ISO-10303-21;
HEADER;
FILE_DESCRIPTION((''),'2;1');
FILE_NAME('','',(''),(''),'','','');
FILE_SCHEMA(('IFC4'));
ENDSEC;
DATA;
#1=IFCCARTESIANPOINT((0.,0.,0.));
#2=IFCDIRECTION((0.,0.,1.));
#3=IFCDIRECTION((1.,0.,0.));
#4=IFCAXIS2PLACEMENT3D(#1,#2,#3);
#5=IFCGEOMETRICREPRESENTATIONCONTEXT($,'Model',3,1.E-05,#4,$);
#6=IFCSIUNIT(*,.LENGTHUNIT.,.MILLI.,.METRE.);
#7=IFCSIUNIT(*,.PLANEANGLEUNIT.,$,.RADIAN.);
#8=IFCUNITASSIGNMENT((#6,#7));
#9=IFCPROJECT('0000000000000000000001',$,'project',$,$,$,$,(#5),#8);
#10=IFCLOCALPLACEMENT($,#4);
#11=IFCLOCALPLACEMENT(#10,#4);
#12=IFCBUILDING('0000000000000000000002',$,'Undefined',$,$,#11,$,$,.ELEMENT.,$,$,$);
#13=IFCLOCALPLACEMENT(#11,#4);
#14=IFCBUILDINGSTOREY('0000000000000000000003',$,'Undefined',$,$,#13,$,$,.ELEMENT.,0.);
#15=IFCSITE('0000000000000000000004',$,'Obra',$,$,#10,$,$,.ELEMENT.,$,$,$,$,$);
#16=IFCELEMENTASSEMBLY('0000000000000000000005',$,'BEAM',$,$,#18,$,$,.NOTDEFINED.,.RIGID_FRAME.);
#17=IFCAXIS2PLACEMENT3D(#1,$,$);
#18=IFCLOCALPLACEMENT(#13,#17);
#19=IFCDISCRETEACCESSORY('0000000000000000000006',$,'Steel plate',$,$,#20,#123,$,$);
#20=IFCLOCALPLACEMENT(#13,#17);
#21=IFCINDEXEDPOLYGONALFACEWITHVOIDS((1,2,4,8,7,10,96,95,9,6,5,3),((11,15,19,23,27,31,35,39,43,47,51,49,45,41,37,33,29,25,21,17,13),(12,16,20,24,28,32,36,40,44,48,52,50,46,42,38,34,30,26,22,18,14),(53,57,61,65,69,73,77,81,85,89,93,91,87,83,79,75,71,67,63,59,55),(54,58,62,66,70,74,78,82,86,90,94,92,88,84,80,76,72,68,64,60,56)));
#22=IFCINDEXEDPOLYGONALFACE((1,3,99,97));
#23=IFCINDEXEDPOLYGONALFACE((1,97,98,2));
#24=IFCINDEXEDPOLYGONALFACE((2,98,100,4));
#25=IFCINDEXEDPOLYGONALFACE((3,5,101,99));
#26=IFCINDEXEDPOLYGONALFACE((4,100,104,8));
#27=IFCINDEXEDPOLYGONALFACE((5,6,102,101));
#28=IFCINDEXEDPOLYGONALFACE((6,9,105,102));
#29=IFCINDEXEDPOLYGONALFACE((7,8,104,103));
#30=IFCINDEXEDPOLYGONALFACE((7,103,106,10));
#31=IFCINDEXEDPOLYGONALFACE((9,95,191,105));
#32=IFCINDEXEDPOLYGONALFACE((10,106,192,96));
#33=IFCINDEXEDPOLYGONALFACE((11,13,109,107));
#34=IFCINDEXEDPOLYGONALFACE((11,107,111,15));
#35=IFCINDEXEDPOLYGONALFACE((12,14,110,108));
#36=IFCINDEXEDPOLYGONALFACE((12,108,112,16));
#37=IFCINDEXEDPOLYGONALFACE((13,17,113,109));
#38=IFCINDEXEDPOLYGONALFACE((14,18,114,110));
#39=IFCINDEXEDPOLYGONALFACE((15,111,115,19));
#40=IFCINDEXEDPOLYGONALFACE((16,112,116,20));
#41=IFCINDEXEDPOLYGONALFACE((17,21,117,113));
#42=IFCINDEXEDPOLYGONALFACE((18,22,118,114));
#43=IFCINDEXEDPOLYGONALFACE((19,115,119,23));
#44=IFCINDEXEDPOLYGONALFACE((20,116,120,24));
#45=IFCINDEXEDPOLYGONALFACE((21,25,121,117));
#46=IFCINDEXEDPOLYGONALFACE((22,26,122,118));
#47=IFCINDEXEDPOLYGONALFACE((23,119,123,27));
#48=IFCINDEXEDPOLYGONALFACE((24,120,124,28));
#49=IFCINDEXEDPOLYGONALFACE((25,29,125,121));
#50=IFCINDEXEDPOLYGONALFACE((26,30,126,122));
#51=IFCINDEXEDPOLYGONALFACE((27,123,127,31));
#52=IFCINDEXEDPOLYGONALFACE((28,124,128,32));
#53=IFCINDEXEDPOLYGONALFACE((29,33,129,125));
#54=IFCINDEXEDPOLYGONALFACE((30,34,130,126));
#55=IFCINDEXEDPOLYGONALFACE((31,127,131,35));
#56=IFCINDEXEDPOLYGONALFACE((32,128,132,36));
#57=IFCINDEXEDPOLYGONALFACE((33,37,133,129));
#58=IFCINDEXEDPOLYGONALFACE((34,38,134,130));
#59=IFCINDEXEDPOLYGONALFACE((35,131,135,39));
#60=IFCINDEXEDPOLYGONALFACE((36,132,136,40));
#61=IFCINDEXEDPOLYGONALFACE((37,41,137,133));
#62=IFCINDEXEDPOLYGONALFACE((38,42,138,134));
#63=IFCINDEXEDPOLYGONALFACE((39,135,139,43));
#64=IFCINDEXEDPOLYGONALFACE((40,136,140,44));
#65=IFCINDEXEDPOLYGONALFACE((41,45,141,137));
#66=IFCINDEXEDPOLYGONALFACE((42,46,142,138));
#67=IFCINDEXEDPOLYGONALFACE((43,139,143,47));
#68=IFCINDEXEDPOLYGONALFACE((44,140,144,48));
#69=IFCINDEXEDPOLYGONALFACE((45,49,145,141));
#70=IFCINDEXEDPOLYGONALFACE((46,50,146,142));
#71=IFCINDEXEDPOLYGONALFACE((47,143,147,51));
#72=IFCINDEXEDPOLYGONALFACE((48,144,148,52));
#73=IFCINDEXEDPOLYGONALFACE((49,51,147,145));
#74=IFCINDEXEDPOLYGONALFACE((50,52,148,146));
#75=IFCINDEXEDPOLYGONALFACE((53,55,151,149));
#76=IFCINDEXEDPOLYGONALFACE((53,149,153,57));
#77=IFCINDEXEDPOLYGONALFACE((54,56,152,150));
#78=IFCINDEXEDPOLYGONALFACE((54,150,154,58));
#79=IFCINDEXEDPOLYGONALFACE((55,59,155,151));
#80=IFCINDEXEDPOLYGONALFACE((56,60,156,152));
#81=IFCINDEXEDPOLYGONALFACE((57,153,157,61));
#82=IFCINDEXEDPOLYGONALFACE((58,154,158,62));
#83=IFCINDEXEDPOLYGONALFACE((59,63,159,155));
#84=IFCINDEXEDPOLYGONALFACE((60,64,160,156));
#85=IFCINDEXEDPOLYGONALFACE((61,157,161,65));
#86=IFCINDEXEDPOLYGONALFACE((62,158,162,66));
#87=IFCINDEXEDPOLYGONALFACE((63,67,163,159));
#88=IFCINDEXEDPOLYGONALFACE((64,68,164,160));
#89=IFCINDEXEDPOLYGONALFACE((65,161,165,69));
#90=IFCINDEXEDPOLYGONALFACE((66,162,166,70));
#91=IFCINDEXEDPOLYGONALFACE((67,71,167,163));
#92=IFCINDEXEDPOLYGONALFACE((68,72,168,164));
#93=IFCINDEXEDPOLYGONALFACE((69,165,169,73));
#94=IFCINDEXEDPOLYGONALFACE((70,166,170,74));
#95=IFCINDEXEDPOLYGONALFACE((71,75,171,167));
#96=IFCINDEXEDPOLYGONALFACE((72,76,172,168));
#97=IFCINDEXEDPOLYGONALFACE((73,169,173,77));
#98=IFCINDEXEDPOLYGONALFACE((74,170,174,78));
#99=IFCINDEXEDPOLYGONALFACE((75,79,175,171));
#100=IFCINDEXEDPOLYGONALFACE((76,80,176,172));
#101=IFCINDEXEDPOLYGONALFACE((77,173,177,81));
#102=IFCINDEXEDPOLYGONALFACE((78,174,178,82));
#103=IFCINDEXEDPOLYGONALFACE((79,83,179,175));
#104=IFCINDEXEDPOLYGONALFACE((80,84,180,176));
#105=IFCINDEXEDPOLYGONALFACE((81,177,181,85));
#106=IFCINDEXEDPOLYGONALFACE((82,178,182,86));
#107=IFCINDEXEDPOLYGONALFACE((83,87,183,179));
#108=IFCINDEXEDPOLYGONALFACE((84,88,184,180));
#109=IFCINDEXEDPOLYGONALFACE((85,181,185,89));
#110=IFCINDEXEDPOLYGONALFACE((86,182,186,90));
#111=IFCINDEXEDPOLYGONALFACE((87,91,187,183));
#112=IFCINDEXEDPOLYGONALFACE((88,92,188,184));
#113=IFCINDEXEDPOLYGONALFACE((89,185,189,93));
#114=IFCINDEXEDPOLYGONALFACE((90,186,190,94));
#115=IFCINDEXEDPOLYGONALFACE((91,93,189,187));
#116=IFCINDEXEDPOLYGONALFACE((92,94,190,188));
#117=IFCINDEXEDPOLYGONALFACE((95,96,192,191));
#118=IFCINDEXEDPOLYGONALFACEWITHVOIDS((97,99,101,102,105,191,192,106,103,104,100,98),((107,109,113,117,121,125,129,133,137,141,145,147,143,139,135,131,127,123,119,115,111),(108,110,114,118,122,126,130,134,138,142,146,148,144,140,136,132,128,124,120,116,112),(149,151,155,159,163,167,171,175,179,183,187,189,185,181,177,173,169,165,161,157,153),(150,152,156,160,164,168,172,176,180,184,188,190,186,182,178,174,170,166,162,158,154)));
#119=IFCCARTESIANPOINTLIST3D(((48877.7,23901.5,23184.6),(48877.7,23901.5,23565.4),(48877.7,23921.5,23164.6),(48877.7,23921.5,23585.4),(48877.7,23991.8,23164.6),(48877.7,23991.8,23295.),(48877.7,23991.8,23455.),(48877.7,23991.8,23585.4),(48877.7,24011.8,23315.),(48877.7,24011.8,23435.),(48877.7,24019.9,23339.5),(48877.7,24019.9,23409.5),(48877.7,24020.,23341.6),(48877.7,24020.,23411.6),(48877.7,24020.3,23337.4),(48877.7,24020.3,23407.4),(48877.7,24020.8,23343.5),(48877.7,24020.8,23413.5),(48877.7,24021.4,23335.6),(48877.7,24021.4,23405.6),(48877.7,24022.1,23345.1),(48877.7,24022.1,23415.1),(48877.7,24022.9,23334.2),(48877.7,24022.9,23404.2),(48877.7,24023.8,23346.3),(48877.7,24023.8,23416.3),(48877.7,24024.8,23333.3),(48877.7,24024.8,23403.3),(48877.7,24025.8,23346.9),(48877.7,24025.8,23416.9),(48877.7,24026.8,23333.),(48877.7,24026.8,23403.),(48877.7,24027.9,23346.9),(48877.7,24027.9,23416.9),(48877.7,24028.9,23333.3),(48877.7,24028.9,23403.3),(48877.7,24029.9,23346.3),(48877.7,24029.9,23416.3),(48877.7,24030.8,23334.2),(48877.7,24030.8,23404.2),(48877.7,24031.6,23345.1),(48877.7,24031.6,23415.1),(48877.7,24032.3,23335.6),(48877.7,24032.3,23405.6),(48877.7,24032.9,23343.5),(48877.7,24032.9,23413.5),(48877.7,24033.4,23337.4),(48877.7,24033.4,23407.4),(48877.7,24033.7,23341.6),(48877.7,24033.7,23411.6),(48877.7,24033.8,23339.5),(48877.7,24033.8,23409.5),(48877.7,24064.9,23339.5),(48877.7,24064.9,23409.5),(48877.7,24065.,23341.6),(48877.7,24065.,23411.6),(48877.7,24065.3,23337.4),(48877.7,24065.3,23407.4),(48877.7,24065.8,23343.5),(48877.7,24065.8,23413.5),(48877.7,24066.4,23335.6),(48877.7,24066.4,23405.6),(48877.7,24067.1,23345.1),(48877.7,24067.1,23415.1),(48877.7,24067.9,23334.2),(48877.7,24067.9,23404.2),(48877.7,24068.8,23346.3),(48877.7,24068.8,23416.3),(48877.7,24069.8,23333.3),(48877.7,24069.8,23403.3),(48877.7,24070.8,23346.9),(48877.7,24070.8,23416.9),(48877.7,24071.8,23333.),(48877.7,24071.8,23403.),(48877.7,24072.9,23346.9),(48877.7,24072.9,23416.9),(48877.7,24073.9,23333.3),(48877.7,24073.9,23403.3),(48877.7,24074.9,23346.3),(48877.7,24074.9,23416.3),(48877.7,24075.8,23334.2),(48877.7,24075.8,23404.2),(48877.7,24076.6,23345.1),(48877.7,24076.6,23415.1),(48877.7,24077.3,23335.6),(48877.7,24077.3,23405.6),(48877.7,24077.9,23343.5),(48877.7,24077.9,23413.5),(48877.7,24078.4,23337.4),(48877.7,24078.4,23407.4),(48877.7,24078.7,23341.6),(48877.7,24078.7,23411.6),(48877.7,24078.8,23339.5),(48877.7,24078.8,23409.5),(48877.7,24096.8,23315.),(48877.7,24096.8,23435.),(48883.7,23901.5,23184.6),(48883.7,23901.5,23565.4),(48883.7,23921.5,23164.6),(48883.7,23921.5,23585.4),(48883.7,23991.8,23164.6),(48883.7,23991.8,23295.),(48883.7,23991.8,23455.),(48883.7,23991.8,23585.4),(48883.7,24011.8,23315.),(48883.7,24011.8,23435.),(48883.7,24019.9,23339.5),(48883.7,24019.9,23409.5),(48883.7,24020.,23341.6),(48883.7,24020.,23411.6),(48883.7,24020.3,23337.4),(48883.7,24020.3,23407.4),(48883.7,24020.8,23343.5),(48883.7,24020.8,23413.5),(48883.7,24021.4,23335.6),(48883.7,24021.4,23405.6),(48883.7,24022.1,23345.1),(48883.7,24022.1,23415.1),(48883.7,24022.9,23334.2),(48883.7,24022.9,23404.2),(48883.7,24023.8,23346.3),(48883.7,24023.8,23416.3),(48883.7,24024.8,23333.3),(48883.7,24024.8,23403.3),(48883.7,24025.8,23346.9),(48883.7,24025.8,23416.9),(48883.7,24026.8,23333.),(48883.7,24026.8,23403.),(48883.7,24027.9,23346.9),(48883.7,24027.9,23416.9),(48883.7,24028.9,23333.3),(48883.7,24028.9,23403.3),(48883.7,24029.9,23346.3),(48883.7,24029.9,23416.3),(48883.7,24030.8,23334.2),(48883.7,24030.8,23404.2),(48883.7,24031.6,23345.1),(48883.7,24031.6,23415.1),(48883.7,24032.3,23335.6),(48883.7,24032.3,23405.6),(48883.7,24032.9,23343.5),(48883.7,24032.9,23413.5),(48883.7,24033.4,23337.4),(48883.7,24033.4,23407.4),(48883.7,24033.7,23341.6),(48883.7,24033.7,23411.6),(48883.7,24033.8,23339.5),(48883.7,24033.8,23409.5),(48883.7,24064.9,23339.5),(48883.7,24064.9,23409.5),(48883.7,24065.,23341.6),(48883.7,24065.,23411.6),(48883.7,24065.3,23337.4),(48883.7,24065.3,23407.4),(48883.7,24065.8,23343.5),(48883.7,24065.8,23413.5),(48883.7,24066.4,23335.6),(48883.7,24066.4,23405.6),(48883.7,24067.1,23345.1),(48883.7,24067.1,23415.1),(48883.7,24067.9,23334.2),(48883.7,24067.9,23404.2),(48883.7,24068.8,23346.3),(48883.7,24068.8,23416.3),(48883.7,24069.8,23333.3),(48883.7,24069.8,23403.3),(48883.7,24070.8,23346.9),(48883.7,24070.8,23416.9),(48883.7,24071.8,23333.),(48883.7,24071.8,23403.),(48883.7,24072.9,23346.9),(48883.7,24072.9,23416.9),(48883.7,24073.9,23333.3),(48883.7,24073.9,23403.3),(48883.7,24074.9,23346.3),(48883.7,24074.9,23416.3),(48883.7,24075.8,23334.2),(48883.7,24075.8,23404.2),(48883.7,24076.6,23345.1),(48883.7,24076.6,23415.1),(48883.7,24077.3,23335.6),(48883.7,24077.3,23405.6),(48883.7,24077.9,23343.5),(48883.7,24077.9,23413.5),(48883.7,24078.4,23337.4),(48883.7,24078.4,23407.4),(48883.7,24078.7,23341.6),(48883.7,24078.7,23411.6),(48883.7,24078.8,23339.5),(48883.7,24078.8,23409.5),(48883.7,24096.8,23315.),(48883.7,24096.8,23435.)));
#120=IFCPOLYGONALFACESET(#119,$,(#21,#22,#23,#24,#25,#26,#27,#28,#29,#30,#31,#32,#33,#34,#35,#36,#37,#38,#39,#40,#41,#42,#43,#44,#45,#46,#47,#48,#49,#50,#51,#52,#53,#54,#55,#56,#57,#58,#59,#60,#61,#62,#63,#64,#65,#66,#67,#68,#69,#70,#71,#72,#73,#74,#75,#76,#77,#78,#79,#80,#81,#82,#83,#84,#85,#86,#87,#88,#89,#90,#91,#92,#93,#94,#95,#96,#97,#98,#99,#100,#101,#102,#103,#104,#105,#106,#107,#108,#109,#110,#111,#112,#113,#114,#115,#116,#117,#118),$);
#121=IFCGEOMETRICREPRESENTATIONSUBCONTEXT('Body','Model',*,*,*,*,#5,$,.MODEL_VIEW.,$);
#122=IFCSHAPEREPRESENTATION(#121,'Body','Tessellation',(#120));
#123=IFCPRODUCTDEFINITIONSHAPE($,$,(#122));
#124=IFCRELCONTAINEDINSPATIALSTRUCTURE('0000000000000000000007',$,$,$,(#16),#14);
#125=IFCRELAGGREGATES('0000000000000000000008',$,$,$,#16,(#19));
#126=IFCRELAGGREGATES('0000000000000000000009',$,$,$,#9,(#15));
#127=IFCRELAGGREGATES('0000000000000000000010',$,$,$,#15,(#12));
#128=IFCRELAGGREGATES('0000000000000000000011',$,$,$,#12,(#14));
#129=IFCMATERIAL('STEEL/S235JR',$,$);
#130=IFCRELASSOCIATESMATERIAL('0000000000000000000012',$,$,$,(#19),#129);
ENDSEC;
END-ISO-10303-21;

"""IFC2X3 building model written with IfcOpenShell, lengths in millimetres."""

from ifc_helpers import new_model, si_unit, frame, origin_with_axes, origin_2d_with_axis, place, context, subcontext, project, spatial, polyline, circle, outline, extrude, source, transform, mapped, material, element, aggregate, save


model = new_model("IFC2X3")

# Units and contexts
model_context = context("Model", 3, precision=1e-05, world=origin_with_axes())
body_context = subcontext(model_context, "Body", "Model", "MODEL_VIEW")
ifc_project = project(units=[si_unit("LENGTHUNIT", "METRE", prefix="MILLI"), si_unit("PLANEANGLEUNIT", "RADIAN")], contexts=[model_context])

# Site, building, storey
site_placement = place(None, origin_with_axes())
site = spatial("IfcSite", under=ifc_project, at=site_placement, Name="Obra", CompositionType="ELEMENT")
building_placement = place(site_placement, origin_with_axes())
building = spatial("IfcBuilding", under=site, at=building_placement, Name="Undefined", CompositionType="ELEMENT")
storey_placement = place(building_placement, origin_with_axes())
storey = spatial("IfcBuildingStorey", under=building, at=storey_placement, Name="Undefined", CompositionType="ELEMENT", Elevation=0.0)

# Shared definitions
ifc_material_1 = material(Name="STEEL/S235JR")

# Element assembly, discrete accessory, opening
assembly_1_placement = place(storey_placement, origin_with_axes())
assembly_1 = element("IfcElementAssembly", 1, at=assembly_1_placement, inside=storey, Name="BEAM", AssemblyPlace="NOTDEFINED", PredefinedType="RIGID_FRAME")
discrete_accessory_1_placement = place(assembly_1_placement, frame((48880.7, 23901.5, 23184.6), z_axis=(1.0, 0.0, 0.0), x_axis=(-0.000001, 0.707107, -0.707107)))
discrete_accessory_1 = element("IfcDiscreteAccessory", 2, at=discrete_accessory_1_placement, material=ifc_material_1, Name="Steel plate", context=body_context, shape_type="SweptSolid", body=[
    extrude(outline(polyline([(0.0, 0.0), (28.3, 0.0), (78.0, 49.7), (-14.2, 141.9), (-14.2, 170.2), (45.9, 230.3), (-39.0, 315.2), (-99.1, 255.1), (-127.3, 255.1), (-219.6, 347.3), (-269.3, 297.6), (-269.3, 269.3), (0.0, 0.0)])), frame((0.0, 0.0, -3.0), z_axis=(0.0, 0.0, 1.0), x_axis=(1.0, 0.0, 0.0)), (0.0, 0.0, 1.0), 6.0),
])
shared_shape_1 = source(origin_with_axes(), body_context, "Body", "SweptSolid", [
    extrude(circle(Radius=7.0, at=origin_2d_with_axis()), frame((0.0, -8.6, 0.0), z_axis=(0.0, 1.0, 0.0), x_axis=(1.0, 0.0, 0.0)), (0.0, 0.0, 1.0), 6.2),
])
opening_1_placement = place(assembly_1_placement, frame((48875.2, 24001.8, 23435.0), z_axis=(0.0, 1.0, 0.0), x_axis=(0.0, 0.0, -1.0)))
element("IfcOpeningElement", 3, at=opening_1_placement, cuts=discrete_accessory_1, ObjectType="Opening", context=body_context, shape_type="MappedRepresentation", body=[
    mapped(shared_shape_1, transform((25.0, 0.0, 25.0))),
    mapped(shared_shape_1, transform((25.0, 0.0, 70.0))),
    mapped(shared_shape_1, transform((95.0, 0.0, 25.0))),
    mapped(shared_shape_1, transform((95.0, 0.0, 70.0))),
])
aggregate(assembly_1, [discrete_accessory_1])

save(model, "model.ifc")
